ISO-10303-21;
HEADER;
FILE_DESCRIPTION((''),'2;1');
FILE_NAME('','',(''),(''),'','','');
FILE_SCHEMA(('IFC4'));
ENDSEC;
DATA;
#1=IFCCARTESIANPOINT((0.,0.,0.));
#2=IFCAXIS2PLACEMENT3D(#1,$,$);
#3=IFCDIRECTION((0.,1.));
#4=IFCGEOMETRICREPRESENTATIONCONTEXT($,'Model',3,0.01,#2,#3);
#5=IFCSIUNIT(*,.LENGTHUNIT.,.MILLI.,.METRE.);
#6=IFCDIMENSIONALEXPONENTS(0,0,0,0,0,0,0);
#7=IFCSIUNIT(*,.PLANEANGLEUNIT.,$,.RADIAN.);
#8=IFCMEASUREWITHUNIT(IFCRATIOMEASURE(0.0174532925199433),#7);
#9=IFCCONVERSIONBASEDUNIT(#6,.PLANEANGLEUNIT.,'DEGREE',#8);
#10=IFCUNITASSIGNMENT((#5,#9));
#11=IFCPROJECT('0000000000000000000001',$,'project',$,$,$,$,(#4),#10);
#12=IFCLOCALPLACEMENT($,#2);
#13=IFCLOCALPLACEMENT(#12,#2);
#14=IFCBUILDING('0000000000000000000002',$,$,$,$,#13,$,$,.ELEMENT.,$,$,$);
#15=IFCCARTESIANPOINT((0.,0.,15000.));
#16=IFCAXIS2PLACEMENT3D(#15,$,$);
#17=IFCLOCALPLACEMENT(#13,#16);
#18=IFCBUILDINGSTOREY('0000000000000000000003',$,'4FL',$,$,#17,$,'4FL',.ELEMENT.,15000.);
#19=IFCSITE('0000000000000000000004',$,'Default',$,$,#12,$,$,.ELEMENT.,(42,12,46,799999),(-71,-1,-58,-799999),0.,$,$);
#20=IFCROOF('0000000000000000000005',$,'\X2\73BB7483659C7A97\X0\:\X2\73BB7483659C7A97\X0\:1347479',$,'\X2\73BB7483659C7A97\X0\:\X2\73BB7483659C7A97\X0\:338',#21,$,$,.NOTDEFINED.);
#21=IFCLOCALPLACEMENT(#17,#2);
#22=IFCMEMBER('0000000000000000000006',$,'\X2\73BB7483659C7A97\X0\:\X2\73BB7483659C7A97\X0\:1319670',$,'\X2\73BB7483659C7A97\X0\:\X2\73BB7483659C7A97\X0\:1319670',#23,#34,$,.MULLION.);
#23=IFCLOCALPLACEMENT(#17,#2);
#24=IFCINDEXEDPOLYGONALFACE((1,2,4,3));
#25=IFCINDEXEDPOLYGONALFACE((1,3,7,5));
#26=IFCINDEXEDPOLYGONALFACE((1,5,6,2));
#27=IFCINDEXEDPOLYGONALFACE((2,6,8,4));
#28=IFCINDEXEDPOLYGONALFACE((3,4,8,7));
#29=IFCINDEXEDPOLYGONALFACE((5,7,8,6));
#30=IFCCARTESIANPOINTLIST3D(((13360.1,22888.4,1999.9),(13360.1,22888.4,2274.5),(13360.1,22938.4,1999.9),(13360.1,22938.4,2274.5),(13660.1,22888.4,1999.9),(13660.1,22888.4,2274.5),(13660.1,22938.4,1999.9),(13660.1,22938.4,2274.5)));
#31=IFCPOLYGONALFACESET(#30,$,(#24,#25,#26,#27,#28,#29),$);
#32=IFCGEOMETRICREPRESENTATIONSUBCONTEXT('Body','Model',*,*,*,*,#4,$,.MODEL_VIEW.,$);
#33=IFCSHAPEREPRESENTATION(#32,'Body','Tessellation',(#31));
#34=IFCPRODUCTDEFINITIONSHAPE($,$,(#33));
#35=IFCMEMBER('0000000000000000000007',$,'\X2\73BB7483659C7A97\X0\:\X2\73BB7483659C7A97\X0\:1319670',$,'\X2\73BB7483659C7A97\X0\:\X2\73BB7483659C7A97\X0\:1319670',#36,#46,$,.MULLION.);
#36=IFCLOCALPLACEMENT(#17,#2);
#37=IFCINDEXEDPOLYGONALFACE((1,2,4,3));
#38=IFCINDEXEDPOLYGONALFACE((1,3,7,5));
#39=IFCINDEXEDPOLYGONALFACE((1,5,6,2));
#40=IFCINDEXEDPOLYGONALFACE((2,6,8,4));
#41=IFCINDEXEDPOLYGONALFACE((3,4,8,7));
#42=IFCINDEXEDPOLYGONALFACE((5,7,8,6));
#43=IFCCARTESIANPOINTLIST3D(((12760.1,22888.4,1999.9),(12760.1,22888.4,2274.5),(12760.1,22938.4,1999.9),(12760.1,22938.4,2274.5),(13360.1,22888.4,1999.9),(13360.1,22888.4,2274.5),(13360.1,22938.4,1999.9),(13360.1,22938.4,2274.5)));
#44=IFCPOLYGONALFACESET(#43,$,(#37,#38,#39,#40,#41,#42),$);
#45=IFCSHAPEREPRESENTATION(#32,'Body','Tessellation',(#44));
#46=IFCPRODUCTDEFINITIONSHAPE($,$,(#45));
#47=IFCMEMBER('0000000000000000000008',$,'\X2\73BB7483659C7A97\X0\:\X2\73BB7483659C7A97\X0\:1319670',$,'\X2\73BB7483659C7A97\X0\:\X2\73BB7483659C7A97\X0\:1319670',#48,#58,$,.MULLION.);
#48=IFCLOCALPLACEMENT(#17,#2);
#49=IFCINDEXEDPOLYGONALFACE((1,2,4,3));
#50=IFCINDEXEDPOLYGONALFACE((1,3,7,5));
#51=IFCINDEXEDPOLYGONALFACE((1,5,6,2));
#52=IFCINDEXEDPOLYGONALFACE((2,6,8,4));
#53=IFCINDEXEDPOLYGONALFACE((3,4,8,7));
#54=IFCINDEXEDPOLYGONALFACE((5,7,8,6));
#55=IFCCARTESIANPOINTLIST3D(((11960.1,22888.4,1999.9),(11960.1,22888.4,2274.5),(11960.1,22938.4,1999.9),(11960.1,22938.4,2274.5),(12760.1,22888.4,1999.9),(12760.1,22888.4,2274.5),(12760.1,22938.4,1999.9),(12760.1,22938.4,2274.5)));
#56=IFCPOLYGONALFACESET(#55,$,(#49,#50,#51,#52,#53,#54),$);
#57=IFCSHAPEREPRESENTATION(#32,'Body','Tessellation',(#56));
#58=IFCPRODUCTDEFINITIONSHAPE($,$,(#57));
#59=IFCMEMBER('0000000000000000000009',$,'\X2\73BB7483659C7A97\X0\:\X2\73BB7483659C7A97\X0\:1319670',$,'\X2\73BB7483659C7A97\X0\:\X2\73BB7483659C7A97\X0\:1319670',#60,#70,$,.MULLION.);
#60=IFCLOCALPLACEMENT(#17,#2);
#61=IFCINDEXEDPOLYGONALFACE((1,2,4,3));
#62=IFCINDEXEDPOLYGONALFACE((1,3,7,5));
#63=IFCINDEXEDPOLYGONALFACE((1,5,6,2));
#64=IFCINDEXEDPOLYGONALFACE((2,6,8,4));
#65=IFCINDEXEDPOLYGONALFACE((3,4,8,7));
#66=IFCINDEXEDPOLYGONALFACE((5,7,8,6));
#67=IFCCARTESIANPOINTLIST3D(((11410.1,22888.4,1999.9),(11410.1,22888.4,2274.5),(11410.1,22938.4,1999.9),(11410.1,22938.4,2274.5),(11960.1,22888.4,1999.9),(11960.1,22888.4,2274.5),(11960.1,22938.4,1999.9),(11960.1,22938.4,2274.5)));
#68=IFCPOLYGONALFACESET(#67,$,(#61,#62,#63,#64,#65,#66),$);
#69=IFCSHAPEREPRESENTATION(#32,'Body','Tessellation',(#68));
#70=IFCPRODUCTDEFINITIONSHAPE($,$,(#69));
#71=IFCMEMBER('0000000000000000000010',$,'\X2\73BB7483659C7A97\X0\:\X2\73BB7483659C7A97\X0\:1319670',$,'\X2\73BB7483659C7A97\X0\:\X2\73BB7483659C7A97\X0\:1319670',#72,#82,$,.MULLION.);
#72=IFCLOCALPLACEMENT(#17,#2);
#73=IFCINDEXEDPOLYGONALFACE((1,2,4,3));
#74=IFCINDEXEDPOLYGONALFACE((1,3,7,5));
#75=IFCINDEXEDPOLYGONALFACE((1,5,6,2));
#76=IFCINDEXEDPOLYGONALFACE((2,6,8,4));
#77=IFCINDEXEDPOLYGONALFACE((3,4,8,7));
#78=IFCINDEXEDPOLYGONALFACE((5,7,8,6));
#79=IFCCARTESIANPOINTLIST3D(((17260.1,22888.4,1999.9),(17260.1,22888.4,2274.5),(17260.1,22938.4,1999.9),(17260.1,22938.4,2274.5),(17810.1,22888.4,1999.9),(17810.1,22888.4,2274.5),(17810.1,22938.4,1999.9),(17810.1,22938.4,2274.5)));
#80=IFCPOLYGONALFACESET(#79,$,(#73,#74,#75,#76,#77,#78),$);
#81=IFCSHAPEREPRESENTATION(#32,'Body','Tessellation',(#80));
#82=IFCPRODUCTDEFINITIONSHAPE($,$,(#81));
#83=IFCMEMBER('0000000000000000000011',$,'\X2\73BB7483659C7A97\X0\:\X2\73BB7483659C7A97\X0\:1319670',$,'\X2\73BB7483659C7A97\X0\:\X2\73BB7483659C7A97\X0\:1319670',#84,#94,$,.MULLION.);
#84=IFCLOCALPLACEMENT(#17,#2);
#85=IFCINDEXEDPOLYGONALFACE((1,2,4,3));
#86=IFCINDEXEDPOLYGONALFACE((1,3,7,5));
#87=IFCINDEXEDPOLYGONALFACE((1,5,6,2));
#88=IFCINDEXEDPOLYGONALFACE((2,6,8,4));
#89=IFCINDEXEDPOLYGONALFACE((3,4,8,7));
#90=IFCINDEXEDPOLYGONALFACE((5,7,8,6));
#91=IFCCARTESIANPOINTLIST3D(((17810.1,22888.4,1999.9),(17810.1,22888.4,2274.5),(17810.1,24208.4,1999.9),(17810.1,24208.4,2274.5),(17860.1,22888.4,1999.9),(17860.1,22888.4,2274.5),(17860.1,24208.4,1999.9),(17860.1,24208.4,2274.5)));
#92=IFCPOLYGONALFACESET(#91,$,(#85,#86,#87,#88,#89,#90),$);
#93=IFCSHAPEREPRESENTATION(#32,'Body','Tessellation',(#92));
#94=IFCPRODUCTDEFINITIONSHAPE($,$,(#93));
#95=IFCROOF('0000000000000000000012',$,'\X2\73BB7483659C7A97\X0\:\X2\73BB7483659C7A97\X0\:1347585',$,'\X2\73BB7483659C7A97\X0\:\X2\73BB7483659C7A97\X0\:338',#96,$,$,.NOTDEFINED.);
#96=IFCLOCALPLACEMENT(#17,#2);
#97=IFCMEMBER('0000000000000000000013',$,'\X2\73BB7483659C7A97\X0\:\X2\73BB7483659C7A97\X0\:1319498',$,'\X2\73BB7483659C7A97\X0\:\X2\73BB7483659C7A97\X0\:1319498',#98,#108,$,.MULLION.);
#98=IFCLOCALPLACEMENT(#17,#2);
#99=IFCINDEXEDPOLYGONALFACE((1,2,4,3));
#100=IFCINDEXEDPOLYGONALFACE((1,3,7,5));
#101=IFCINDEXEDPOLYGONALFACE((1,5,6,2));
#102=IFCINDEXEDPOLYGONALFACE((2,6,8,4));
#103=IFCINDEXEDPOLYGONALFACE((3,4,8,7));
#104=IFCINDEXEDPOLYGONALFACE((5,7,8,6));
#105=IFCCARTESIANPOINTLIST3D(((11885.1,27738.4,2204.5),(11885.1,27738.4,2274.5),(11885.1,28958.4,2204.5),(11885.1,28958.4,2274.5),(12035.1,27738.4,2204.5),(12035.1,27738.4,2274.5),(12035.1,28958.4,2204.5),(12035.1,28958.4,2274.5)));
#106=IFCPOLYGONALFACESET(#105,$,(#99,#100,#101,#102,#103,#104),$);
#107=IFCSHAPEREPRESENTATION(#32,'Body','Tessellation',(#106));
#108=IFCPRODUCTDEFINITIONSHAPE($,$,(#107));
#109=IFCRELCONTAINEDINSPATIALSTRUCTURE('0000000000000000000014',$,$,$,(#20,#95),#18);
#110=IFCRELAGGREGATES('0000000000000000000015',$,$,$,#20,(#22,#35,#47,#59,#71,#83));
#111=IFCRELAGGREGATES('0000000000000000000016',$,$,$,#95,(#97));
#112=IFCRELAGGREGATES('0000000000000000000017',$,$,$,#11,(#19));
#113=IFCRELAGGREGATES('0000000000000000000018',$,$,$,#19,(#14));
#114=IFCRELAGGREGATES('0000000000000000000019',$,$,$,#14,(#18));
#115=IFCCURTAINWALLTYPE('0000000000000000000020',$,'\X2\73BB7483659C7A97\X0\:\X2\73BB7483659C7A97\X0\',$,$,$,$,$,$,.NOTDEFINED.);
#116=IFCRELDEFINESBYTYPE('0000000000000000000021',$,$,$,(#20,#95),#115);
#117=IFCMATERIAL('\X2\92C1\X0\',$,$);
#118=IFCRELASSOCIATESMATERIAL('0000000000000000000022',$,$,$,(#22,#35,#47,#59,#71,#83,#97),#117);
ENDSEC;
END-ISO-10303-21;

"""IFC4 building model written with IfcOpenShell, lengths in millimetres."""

from ifc_helpers import new_model, entity, si_unit, converted_unit, direction, frame, frame_2d, origin, place, context, subcontext, project, spatial, rectangle, extrude, material, type_object, element, aggregate, save


model = new_model("IFC4")

# Units and contexts
model_context = context("Model", 3, precision=0.01, world=origin(), true_north=direction((0.0, 1.0)))
body_context = subcontext(model_context, "Body", "Model", "MODEL_VIEW")
ifc_project = project(units=[si_unit("LENGTHUNIT", "METRE", prefix="MILLI"), converted_unit("PLANEANGLEUNIT", "DEGREE", entity("IfcRatioMeasure", 0.0174532925199433), si_unit("PLANEANGLEUNIT", "RADIAN"), dimensions=[0, 0, 0, 0, 0, 0, 0])], contexts=[model_context])

# Site, building, storey
site_placement = place(None, origin())
site = spatial("IfcSite", under=ifc_project, at=site_placement, Name="Default", CompositionType="ELEMENT", RefLatitude=(42, 12, 46, 799999), RefLongitude=(-71, -1, -58, -799999), RefElevation=0.0)
building_placement = place(site_placement, origin())
building = spatial("IfcBuilding", under=site, at=building_placement, CompositionType="ELEMENT")
storey_placement = place(building_placement, frame((0.0, 0.0, 15000.0)))
storey = spatial("IfcBuildingStorey", under=building, at=storey_placement, Name="4FL", LongName="4FL", CompositionType="ELEMENT", Elevation=15000.0)

# Roof, members
curtain_wall_type = type_object("IfcCurtainWallType", Name="玻璃斜窗:玻璃斜窗", PredefinedType="NOTDEFINED")
roof_1_placement = place(storey_placement, frame((0.0, 0.0, -15000.0)))
roof_1 = element("IfcRoof", 1, at=roof_1_placement, inside=storey, type_object=curtain_wall_type, Name="玻璃斜窗:玻璃斜窗:1347479", ObjectType="玻璃斜窗:玻璃斜窗:338", PredefinedType="NOTDEFINED")
ifc_material = material(Name="鋁")
member_1_placement = place(roof_1_placement, frame((0.0, 0.0, 15000.0)))
member_1 = element("IfcMember", 2, at=member_1_placement, material=ifc_material, Name="玻璃斜窗:玻璃斜窗:1319670", ObjectType="玻璃斜窗:玻璃斜窗:1319670", PredefinedType="MULLION", context=body_context, shape_type="SweptSolid", body=[
    extrude(rectangle(XDim=274.5, YDim=50.0, at=frame_2d((0.0, 0.0), x_axis=(1.0, 0.0))), frame((13660.1, 22913.4, 2137.2), z_axis=(-1.0, 0.0, 0.0), x_axis=(0.0, 0.0, -1.0)), (0.0, 0.0, 1.0), 300.0),
])
member_2_placement = place(roof_1_placement, frame((0.0, 0.0, 15000.0)))
member_2 = element("IfcMember", 3, at=member_2_placement, material=ifc_material, Name="玻璃斜窗:玻璃斜窗:1319670", ObjectType="玻璃斜窗:玻璃斜窗:1319670", PredefinedType="MULLION", context=body_context, shape_type="SweptSolid", body=[
    extrude(rectangle(XDim=274.5, YDim=50.0, at=frame_2d((0.0, 0.0), x_axis=(1.0, 0.0))), frame((13360.1, 22913.4, 2137.2), z_axis=(-1.0, 0.0, 0.0), x_axis=(0.0, 0.0, -1.0)), (0.0, 0.0, 1.0), 600.0),
])
member_3_placement = place(roof_1_placement, frame((0.0, 0.0, 15000.0)))
member_3 = element("IfcMember", 4, at=member_3_placement, material=ifc_material, Name="玻璃斜窗:玻璃斜窗:1319670", ObjectType="玻璃斜窗:玻璃斜窗:1319670", PredefinedType="MULLION", context=body_context, shape_type="SweptSolid", body=[
    extrude(rectangle(XDim=274.5, YDim=50.0, at=frame_2d((0.0, 0.0), x_axis=(1.0, 0.0))), frame((12760.1, 22913.4, 2137.2), z_axis=(-1.0, 0.0, 0.0), x_axis=(0.0, 0.0, -1.0)), (0.0, 0.0, 1.0), 800.0),
])
member_4_placement = place(roof_1_placement, frame((0.0, 0.0, 15000.0)))
member_4 = element("IfcMember", 5, at=member_4_placement, material=ifc_material, Name="玻璃斜窗:玻璃斜窗:1319670", ObjectType="玻璃斜窗:玻璃斜窗:1319670", PredefinedType="MULLION", context=body_context, shape_type="SweptSolid", body=[
    extrude(rectangle(XDim=274.5, YDim=50.0, at=frame_2d((0.0, 0.0), x_axis=(1.0, 0.0))), frame((11960.1, 22913.4, 2137.2), z_axis=(-1.0, 0.0, 0.0), x_axis=(0.0, 0.0, -1.0)), (0.0, 0.0, 1.0), 550.0),
])
member_5_placement = place(roof_1_placement, frame((0.0, 0.0, 15000.0)))
member_5 = element("IfcMember", 6, at=member_5_placement, material=ifc_material, Name="玻璃斜窗:玻璃斜窗:1319670", ObjectType="玻璃斜窗:玻璃斜窗:1319670", PredefinedType="MULLION", context=body_context, shape_type="SweptSolid", body=[
    extrude(rectangle(XDim=274.5, YDim=50.0, at=frame_2d((0.0, 0.0), x_axis=(1.0, 0.0))), frame((17810.1, 22913.4, 2137.2), z_axis=(-1.0, 0.0, 0.0), x_axis=(0.0, 0.0, -1.0)), (0.0, 0.0, 1.0), 550.0),
])
member_6_placement = place(roof_1_placement, frame((0.0, 0.0, 15000.0)))
member_6 = element("IfcMember", 7, at=member_6_placement, material=ifc_material, Name="玻璃斜窗:玻璃斜窗:1319670", ObjectType="玻璃斜窗:玻璃斜窗:1319670", PredefinedType="MULLION", context=body_context, shape_type="SweptSolid", body=[
    extrude(rectangle(XDim=274.5, YDim=50.0, at=frame_2d((0.0, 0.0), x_axis=(1.0, 0.0))), frame((17835.1, 24208.4, 2137.2), z_axis=(0.0, -1.0, 0.0), x_axis=(0.0, 0.0, -1.0)), (0.0, 0.0, 1.0), 1320.0),
])
aggregate(roof_1, [member_1, member_2, member_3, member_4, member_5, member_6])

# Roof, member
roof_2_placement = place(storey_placement, frame((0.0, 0.0, -15000.0)))
roof_2 = element("IfcRoof", 8, at=roof_2_placement, inside=storey, type_object=curtain_wall_type, Name="玻璃斜窗:玻璃斜窗:1347585", ObjectType="玻璃斜窗:玻璃斜窗:338", PredefinedType="NOTDEFINED")
member_7_placement = place(roof_2_placement, frame((0.0, 0.0, 15000.0)))
member_7 = element("IfcMember", 9, at=member_7_placement, material=ifc_material, Name="玻璃斜窗:玻璃斜窗:1319498", ObjectType="玻璃斜窗:玻璃斜窗:1319498", PredefinedType="MULLION", context=body_context, shape_type="SweptSolid", body=[
    extrude(rectangle(XDim=70.0, YDim=150.0, at=frame_2d((0.0, 0.0), x_axis=(1.0, 0.0))), frame((11960.1, 27738.4, 2239.5), z_axis=(0.0, 1.0, 0.0), x_axis=(0.0, 0.0, -1.0)), (0.0, 0.0, 1.0), 1220.0),
])
aggregate(roof_2, [member_7])

save(model, "model.ifc")
